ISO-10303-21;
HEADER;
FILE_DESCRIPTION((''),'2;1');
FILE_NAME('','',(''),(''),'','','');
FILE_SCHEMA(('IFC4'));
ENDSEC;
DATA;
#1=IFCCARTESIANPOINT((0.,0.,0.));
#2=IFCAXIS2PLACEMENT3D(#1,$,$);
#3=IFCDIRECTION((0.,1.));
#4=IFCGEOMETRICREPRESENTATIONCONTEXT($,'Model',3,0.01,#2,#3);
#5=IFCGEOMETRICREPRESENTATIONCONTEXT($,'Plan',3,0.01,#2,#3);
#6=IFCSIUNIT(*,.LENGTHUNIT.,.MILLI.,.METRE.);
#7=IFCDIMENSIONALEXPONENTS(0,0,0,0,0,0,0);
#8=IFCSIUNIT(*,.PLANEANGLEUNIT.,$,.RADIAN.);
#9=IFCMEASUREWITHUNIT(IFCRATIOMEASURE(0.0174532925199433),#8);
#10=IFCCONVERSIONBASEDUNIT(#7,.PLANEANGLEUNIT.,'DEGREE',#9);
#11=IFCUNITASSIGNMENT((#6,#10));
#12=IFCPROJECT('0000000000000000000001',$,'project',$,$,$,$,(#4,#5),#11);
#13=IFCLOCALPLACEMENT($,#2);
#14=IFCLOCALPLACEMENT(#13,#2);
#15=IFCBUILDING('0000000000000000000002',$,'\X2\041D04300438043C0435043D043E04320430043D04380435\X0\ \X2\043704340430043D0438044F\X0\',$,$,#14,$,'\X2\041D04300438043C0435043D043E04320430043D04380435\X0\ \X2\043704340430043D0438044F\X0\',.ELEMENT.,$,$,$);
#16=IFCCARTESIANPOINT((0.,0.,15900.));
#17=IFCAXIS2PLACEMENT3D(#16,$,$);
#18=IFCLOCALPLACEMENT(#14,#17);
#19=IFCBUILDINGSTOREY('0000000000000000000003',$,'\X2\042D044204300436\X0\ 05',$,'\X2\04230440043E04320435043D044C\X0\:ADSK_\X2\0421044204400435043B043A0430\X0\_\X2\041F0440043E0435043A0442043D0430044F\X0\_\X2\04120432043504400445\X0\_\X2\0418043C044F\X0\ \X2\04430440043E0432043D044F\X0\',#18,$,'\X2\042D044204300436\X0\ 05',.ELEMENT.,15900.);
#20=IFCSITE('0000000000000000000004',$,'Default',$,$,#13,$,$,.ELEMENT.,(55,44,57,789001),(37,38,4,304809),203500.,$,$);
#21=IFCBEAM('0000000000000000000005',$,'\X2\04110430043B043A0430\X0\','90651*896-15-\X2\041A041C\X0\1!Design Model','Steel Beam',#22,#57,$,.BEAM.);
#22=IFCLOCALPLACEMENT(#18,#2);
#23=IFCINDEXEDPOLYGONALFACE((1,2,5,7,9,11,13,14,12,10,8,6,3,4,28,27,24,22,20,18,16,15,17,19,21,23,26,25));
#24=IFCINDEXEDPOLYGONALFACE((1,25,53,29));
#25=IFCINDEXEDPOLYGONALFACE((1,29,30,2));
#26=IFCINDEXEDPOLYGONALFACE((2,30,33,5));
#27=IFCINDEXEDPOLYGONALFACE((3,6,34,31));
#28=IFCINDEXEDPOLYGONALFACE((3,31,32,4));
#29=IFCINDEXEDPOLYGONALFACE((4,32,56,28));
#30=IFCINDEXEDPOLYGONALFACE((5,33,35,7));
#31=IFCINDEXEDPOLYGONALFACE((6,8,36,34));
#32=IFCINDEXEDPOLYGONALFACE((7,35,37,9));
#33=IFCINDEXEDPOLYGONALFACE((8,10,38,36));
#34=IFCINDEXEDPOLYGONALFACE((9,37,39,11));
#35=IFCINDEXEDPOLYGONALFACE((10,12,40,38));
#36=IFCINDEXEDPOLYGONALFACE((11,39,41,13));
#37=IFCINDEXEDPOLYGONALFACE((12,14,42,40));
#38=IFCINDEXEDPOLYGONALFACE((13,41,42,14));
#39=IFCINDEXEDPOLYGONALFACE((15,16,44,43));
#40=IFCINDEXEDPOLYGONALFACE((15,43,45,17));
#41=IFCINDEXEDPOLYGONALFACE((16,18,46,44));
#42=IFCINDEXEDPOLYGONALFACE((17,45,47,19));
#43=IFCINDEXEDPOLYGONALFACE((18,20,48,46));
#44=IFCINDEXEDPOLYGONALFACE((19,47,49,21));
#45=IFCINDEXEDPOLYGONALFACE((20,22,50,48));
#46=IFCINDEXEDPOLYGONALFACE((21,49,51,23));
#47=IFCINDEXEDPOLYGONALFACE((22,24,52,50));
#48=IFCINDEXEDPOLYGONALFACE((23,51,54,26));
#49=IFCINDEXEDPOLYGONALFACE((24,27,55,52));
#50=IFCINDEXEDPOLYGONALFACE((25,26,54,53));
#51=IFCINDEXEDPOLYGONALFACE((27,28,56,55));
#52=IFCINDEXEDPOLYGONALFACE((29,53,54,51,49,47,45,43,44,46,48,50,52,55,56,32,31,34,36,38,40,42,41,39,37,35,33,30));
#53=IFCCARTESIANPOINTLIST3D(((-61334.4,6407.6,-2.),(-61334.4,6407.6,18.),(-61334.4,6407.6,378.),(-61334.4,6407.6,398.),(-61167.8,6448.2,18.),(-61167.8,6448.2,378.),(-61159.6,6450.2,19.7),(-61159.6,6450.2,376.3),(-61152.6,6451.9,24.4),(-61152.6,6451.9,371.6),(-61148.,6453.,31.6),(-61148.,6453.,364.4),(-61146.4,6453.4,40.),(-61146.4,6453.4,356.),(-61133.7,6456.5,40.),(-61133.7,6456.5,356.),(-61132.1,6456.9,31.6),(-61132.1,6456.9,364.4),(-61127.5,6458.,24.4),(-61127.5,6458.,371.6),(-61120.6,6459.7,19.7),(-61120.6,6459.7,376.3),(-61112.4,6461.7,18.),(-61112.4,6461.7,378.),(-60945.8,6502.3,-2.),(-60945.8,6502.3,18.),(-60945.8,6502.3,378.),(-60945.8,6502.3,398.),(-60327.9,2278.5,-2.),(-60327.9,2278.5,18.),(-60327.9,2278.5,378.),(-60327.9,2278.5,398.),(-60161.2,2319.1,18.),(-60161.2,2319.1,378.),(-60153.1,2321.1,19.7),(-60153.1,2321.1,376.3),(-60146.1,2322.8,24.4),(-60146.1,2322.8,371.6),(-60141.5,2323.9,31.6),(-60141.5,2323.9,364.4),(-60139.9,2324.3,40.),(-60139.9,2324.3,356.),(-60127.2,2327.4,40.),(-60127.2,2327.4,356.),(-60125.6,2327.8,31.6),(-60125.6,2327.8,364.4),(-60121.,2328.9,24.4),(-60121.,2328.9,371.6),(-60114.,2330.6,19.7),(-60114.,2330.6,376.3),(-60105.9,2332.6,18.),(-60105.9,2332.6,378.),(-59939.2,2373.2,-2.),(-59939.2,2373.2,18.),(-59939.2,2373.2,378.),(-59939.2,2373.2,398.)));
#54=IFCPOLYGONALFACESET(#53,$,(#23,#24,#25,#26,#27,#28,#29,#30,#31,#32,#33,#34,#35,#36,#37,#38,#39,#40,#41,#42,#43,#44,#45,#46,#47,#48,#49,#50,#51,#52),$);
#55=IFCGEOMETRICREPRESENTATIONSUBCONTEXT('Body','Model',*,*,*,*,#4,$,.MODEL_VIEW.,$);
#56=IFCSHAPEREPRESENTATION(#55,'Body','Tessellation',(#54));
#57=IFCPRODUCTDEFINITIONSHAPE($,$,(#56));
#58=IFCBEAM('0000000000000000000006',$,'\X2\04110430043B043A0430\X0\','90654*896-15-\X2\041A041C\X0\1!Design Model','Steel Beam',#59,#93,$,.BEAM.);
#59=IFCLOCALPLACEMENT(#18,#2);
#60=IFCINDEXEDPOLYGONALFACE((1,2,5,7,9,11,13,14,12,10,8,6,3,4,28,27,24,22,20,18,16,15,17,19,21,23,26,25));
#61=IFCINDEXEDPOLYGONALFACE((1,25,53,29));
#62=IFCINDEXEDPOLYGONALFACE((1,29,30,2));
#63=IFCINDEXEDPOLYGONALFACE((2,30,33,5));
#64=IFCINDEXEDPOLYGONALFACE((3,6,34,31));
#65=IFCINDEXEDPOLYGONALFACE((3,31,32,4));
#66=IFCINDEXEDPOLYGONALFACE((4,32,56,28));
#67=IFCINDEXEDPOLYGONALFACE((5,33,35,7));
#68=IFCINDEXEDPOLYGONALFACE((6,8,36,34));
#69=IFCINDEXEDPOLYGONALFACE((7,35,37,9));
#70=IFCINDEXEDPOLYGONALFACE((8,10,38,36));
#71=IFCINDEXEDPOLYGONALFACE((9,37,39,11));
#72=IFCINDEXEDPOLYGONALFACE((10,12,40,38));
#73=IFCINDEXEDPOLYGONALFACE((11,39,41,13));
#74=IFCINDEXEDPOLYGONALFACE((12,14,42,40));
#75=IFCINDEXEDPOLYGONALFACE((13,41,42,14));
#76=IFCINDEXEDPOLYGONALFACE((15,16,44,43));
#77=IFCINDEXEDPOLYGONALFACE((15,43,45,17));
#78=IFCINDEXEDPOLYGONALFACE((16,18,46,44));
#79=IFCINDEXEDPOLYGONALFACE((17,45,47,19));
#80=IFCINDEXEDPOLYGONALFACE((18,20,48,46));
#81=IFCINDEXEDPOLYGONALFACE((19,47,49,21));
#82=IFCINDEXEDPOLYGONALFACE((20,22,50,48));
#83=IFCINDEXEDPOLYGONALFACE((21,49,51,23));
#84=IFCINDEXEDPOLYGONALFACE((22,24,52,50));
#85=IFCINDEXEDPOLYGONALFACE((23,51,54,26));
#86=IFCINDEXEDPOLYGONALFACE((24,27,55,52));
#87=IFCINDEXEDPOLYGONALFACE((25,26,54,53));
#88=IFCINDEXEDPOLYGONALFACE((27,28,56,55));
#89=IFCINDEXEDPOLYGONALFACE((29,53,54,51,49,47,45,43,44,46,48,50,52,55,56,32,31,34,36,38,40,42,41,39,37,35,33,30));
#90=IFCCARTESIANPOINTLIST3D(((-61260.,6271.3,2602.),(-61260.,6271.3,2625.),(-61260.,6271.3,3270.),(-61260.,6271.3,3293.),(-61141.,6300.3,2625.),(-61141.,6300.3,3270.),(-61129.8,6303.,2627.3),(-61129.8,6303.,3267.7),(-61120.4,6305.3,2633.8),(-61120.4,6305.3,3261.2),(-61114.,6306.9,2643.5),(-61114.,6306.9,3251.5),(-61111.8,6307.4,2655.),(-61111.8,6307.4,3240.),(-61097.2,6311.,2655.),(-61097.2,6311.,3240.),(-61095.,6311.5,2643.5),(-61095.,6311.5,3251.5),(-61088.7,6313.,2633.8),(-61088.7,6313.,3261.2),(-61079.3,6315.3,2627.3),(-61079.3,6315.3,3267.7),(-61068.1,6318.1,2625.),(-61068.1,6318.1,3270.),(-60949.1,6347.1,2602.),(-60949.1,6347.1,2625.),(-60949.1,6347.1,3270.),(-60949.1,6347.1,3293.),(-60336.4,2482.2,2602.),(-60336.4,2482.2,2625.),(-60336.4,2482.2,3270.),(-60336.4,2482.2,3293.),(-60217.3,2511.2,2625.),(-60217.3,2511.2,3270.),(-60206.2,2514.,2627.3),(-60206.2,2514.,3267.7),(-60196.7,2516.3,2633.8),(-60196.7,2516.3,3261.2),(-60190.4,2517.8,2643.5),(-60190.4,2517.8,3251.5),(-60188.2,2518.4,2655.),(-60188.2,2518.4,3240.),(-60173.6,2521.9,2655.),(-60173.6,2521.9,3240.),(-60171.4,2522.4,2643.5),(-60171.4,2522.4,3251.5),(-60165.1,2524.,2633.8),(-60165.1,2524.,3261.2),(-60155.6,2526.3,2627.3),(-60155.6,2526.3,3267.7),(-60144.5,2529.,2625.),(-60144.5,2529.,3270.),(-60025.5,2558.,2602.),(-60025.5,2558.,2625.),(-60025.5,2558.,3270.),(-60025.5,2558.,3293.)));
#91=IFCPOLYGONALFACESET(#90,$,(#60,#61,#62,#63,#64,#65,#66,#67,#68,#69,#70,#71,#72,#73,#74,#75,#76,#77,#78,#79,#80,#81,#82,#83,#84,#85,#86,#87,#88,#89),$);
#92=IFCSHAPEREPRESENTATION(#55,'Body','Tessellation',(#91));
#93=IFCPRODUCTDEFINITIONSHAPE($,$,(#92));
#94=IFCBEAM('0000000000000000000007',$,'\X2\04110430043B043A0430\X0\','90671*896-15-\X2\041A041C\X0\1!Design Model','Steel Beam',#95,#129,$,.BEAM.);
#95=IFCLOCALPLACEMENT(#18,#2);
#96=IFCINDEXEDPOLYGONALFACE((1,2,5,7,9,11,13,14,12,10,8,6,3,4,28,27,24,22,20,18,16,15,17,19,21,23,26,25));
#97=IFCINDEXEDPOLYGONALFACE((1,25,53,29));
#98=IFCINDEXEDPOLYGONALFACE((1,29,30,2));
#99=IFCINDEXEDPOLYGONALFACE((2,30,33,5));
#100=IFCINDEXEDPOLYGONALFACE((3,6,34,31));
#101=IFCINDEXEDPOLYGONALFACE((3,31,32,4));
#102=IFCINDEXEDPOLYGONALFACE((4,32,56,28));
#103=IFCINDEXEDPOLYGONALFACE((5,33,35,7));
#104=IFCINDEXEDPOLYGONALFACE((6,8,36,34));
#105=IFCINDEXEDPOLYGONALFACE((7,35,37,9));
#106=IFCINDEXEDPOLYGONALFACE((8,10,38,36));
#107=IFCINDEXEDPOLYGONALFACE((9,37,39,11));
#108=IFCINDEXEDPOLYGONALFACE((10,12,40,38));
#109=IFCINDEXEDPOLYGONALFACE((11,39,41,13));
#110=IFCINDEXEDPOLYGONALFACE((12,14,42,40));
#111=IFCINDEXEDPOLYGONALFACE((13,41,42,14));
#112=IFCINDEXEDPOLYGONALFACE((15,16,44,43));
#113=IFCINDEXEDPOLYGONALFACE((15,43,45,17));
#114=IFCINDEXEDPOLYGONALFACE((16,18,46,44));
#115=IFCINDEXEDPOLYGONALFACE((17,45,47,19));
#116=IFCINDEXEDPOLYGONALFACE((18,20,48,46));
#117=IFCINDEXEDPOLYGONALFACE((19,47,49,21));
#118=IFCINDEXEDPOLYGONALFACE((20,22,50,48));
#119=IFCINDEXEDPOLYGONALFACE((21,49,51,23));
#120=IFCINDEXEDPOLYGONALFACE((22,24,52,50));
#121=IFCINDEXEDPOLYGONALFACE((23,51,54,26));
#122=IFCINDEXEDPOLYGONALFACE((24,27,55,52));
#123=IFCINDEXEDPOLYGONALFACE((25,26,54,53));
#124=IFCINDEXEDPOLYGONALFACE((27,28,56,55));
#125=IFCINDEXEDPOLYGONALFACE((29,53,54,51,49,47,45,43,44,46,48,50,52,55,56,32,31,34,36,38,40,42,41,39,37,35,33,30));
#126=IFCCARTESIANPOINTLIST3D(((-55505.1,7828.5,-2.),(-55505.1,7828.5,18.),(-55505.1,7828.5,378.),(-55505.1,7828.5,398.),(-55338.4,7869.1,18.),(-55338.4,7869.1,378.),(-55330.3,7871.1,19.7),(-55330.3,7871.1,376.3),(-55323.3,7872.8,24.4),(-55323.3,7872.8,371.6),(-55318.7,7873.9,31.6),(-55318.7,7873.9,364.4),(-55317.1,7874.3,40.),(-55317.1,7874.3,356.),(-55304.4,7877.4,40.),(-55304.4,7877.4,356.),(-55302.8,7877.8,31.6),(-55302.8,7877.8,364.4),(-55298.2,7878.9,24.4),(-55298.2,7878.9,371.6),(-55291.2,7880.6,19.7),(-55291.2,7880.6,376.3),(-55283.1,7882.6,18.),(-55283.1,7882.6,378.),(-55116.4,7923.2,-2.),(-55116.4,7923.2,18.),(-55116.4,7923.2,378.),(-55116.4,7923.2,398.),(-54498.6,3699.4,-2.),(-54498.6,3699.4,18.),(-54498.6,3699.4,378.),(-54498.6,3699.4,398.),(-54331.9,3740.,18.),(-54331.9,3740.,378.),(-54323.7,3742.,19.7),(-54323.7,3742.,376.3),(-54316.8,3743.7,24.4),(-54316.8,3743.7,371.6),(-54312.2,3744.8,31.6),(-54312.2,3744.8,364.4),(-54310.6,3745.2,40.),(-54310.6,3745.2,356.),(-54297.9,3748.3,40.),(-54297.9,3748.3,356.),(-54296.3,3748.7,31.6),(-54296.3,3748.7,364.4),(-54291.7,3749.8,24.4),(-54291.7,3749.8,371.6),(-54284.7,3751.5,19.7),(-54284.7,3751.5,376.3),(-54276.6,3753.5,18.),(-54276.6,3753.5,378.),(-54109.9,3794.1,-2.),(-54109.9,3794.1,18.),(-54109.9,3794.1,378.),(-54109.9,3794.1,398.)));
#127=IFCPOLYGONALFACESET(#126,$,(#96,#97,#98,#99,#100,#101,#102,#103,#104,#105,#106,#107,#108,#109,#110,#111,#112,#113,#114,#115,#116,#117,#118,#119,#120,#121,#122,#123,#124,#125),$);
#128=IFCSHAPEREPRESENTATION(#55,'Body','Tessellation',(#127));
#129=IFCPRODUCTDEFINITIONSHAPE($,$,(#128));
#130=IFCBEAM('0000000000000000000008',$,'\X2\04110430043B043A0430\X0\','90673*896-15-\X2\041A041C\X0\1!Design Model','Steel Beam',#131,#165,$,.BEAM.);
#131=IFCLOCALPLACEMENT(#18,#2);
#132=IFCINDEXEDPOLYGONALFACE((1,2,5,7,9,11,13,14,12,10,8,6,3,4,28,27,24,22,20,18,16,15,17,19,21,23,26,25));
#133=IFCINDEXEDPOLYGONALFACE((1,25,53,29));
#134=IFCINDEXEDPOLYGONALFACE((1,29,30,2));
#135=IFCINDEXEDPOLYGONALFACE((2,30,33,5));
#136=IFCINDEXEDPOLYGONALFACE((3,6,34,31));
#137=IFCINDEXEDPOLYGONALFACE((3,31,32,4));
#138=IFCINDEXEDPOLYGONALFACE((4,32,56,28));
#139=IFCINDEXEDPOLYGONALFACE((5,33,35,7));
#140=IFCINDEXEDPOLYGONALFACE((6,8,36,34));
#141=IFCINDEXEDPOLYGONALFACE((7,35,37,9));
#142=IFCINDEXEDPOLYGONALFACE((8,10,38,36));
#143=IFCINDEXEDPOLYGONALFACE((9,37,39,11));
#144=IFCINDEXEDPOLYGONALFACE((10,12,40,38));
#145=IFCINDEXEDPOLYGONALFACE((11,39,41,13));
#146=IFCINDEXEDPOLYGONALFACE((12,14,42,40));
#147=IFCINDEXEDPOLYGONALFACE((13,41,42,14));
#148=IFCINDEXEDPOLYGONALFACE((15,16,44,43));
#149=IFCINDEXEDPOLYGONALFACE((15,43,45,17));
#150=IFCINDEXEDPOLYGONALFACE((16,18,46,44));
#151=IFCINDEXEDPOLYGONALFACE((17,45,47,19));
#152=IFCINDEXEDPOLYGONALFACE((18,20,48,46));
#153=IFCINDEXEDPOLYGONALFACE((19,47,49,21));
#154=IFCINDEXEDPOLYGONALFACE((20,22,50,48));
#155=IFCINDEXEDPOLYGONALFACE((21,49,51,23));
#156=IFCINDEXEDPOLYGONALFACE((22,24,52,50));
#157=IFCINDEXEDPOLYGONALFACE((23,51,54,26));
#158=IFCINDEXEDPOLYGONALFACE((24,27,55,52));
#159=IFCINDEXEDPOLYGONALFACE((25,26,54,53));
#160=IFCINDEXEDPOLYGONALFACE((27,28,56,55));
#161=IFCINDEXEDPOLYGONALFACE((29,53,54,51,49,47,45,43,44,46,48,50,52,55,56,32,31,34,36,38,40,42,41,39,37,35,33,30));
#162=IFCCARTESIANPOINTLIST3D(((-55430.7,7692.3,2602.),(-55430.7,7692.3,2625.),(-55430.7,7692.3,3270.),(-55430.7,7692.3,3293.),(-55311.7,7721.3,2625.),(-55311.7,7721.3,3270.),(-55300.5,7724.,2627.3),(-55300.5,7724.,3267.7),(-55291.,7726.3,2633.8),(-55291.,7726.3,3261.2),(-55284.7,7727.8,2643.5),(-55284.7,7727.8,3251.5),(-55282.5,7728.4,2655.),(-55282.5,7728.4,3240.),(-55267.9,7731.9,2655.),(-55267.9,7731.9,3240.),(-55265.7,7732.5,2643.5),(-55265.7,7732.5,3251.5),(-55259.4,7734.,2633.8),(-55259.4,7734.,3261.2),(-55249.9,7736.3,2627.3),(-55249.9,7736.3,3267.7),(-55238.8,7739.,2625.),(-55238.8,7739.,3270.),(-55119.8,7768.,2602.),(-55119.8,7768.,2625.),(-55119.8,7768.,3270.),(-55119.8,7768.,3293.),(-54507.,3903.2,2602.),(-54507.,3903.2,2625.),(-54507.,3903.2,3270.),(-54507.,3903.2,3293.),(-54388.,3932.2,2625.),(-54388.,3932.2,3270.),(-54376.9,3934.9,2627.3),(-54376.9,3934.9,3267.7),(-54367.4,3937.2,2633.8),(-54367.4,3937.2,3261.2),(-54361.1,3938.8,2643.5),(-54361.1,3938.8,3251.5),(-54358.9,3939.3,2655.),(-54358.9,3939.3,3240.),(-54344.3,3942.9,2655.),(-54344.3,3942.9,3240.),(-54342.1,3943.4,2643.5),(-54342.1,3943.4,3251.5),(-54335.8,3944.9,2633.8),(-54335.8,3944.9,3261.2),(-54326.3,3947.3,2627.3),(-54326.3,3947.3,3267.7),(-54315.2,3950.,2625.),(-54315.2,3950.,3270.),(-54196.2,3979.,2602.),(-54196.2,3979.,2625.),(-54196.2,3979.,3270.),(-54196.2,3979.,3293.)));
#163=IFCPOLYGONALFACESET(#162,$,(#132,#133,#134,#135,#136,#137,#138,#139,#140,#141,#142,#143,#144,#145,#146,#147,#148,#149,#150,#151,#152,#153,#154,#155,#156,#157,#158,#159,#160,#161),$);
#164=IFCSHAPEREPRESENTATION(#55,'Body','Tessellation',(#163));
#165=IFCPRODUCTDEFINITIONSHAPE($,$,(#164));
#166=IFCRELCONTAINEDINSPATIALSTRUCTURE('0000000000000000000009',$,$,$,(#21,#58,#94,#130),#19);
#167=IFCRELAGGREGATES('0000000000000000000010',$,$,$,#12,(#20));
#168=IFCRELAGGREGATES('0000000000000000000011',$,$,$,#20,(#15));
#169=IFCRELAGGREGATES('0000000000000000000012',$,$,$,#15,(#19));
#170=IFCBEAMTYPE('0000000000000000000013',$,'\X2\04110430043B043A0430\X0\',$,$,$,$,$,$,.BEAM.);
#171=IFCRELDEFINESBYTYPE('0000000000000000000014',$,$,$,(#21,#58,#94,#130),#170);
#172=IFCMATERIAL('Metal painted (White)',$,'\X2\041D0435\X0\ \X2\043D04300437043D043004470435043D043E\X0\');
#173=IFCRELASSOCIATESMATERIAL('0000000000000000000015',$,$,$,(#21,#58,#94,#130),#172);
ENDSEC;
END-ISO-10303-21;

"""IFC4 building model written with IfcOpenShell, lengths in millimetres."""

from ifc_helpers import new_model, entity, si_unit, converted_unit, direction, frame, origin, place, context, subcontext, project, spatial, indexed_curve, outline, extrude, material, type_object, element, save


model = new_model("IFC4")

# Units and contexts
model_context = context("Model", 3, precision=0.01, world=origin(), true_north=direction((0.0, 1.0)))
plan_context = context("Plan", 3, precision=0.01, world=origin(), true_north=direction((0.0, 1.0)))
body_context = subcontext(model_context, "Body", "Model", "MODEL_VIEW")
ifc_project = project(units=[si_unit("LENGTHUNIT", "METRE", prefix="MILLI"), converted_unit("PLANEANGLEUNIT", "DEGREE", entity("IfcRatioMeasure", 0.0174532925199433), si_unit("PLANEANGLEUNIT", "RADIAN"), dimensions=[0, 0, 0, 0, 0, 0, 0])], contexts=[model_context, plan_context])

# Site, building, storey
site_placement = place(None, origin())
site = spatial("IfcSite", under=ifc_project, at=site_placement, Name="Default", CompositionType="ELEMENT", RefLatitude=(55, 44, 57, 789001), RefLongitude=(37, 38, 4, 304809), RefElevation=203500.0)
building_placement = place(site_placement, origin())
building = spatial("IfcBuilding", under=site, at=building_placement, Name="Наименование здания", LongName="Наименование здания", CompositionType="ELEMENT")
storey_placement = place(building_placement, frame((0.0, 0.0, 15900.0)))
storey = spatial("IfcBuildingStorey", under=building, at=storey_placement, Name="Этаж 05", ObjectType="Уровень:ADSK_Стрелка_Проектная_Вверх_Имя уровня", LongName="Этаж 05", CompositionType="ELEMENT", Elevation=15900.0)

# Shared definitions
placement = place(storey_placement, origin())

# Beams
ifc_material_1 = material(Name="Metal painted (White)", Category="Не назначено")
beam_type = type_object("IfcBeamType", Name="Балка", PredefinedType="BEAM")
element("IfcBeam", 1, at=placement, inside=storey, type_object=beam_type, material=ifc_material_1, Name="Балка", Description="90651*896-15-КМ1!Design Model", ObjectType="Steel Beam", PredefinedType="BEAM", context=body_context, shape_type="SweptSolid", body=[
    extrude(outline(indexed_curve([(-200.0, -200.0), (-180.0, -200.0), (-180.0, -28.5), (-178.3, -20.1), (-173.6, -12.9), (-166.4, -8.2), (-158.0, -6.5), (158.0, -6.5), (166.4, -8.2), (173.6, -12.9), (178.3, -20.1), (180.0, -28.5), (180.0, -200.0), (200.0, -200.0), (200.0, 200.0), (180.0, 200.0), (180.0, 28.5), (178.3, 20.1), (173.6, 12.9), (166.4, 8.2), (158.0, 6.5), (-158.0, 6.5), (-166.4, 8.2), (-173.6, 12.9), (-178.3, 20.1), (-180.0, 28.5), (-180.0, 200.0), (-200.0, 200.0), (-200.0, -200.0)], self_intersect=False)), frame((-60133.6, 2325.8, 198.0), z_axis=(-0.236826, 0.971552, 0.0), x_axis=(0.0, 0.0, 1.0)), (0.0, 0.0, 1.0), 4250.0),
])
element("IfcBeam", 2, at=placement, inside=storey, type_object=beam_type, material=ifc_material_1, Name="Балка", Description="90654*896-15-КМ1!Design Model", ObjectType="Steel Beam", PredefinedType="BEAM", context=body_context, shape_type="SweptSolid", body=[
    extrude(outline(indexed_curve([(-345.5, -160.0), (-322.5, -160.0), (-322.5, -37.5), (-320.2, -26.0), (-313.7, -16.3), (-304.0, -9.8), (-292.5, -7.5), (292.5, -7.5), (304.0, -9.8), (313.7, -16.3), (320.2, -26.0), (322.5, -37.5), (322.5, -160.0), (345.5, -160.0), (345.5, 160.0), (322.5, 160.0), (322.5, 37.5), (320.2, 26.0), (313.7, 16.3), (304.0, 9.8), (292.5, 7.5), (-292.5, 7.5), (-304.0, 9.8), (-313.7, 16.3), (-320.2, 26.0), (-322.5, 37.5), (-322.5, 160.0), (-345.5, 160.0), (-345.5, -160.0)], self_intersect=False)), frame((-60180.9, 2520.1, 2947.5), z_axis=(-0.236826, 0.971552, 0.0), x_axis=(0.0, 0.0, 1.0)), (0.0, 0.0, 1.0), 3900.0),
])
element("IfcBeam", 3, at=placement, inside=storey, type_object=beam_type, material=ifc_material_1, Name="Балка", Description="90671*896-15-КМ1!Design Model", ObjectType="Steel Beam", PredefinedType="BEAM", context=body_context, shape_type="SweptSolid", body=[
    extrude(outline(indexed_curve([(-200.0, -200.0), (-180.0, -200.0), (-180.0, -28.5), (-178.3, -20.1), (-173.6, -12.9), (-166.4, -8.2), (-158.0, -6.5), (158.0, -6.5), (166.4, -8.2), (173.6, -12.9), (178.3, -20.1), (180.0, -28.5), (180.0, -200.0), (200.0, -200.0), (200.0, 200.0), (180.0, 200.0), (180.0, 28.5), (178.3, 20.1), (173.6, 12.9), (166.4, 8.2), (158.0, 6.5), (-158.0, 6.5), (-166.4, 8.2), (-173.6, 12.9), (-178.3, 20.1), (-180.0, 28.5), (-180.0, 200.0), (-200.0, 200.0), (-200.0, -200.0)], self_intersect=False)), frame((-54304.2, 3746.8, 198.0), z_axis=(-0.236826, 0.971552, 0.0), x_axis=(0.0, 0.0, 1.0)), (0.0, 0.0, 1.0), 4250.0),
])
element("IfcBeam", 4, at=placement, inside=storey, type_object=beam_type, material=ifc_material_1, Name="Балка", Description="90673*896-15-КМ1!Design Model", ObjectType="Steel Beam", PredefinedType="BEAM", context=body_context, shape_type="SweptSolid", body=[
    extrude(outline(indexed_curve([(-345.5, -160.0), (-322.5, -160.0), (-322.5, -37.5), (-320.2, -26.0), (-313.7, -16.3), (-304.0, -9.8), (-292.5, -7.5), (292.5, -7.5), (304.0, -9.8), (313.7, -16.3), (320.2, -26.0), (322.5, -37.5), (322.5, -160.0), (345.5, -160.0), (345.5, 160.0), (322.5, 160.0), (322.5, 37.5), (320.2, 26.0), (313.7, 16.3), (304.0, 9.8), (292.5, 7.5), (-292.5, 7.5), (-304.0, 9.8), (-313.7, 16.3), (-320.2, 26.0), (-322.5, 37.5), (-322.5, 160.0), (-345.5, 160.0), (-345.5, -160.0)], self_intersect=False)), frame((-54351.6, 3941.1, 2947.5), z_axis=(-0.236826, 0.971552, 0.0), x_axis=(0.0, 0.0, 1.0)), (0.0, 0.0, 1.0), 3900.0),
])

save(model, "model.ifc")
